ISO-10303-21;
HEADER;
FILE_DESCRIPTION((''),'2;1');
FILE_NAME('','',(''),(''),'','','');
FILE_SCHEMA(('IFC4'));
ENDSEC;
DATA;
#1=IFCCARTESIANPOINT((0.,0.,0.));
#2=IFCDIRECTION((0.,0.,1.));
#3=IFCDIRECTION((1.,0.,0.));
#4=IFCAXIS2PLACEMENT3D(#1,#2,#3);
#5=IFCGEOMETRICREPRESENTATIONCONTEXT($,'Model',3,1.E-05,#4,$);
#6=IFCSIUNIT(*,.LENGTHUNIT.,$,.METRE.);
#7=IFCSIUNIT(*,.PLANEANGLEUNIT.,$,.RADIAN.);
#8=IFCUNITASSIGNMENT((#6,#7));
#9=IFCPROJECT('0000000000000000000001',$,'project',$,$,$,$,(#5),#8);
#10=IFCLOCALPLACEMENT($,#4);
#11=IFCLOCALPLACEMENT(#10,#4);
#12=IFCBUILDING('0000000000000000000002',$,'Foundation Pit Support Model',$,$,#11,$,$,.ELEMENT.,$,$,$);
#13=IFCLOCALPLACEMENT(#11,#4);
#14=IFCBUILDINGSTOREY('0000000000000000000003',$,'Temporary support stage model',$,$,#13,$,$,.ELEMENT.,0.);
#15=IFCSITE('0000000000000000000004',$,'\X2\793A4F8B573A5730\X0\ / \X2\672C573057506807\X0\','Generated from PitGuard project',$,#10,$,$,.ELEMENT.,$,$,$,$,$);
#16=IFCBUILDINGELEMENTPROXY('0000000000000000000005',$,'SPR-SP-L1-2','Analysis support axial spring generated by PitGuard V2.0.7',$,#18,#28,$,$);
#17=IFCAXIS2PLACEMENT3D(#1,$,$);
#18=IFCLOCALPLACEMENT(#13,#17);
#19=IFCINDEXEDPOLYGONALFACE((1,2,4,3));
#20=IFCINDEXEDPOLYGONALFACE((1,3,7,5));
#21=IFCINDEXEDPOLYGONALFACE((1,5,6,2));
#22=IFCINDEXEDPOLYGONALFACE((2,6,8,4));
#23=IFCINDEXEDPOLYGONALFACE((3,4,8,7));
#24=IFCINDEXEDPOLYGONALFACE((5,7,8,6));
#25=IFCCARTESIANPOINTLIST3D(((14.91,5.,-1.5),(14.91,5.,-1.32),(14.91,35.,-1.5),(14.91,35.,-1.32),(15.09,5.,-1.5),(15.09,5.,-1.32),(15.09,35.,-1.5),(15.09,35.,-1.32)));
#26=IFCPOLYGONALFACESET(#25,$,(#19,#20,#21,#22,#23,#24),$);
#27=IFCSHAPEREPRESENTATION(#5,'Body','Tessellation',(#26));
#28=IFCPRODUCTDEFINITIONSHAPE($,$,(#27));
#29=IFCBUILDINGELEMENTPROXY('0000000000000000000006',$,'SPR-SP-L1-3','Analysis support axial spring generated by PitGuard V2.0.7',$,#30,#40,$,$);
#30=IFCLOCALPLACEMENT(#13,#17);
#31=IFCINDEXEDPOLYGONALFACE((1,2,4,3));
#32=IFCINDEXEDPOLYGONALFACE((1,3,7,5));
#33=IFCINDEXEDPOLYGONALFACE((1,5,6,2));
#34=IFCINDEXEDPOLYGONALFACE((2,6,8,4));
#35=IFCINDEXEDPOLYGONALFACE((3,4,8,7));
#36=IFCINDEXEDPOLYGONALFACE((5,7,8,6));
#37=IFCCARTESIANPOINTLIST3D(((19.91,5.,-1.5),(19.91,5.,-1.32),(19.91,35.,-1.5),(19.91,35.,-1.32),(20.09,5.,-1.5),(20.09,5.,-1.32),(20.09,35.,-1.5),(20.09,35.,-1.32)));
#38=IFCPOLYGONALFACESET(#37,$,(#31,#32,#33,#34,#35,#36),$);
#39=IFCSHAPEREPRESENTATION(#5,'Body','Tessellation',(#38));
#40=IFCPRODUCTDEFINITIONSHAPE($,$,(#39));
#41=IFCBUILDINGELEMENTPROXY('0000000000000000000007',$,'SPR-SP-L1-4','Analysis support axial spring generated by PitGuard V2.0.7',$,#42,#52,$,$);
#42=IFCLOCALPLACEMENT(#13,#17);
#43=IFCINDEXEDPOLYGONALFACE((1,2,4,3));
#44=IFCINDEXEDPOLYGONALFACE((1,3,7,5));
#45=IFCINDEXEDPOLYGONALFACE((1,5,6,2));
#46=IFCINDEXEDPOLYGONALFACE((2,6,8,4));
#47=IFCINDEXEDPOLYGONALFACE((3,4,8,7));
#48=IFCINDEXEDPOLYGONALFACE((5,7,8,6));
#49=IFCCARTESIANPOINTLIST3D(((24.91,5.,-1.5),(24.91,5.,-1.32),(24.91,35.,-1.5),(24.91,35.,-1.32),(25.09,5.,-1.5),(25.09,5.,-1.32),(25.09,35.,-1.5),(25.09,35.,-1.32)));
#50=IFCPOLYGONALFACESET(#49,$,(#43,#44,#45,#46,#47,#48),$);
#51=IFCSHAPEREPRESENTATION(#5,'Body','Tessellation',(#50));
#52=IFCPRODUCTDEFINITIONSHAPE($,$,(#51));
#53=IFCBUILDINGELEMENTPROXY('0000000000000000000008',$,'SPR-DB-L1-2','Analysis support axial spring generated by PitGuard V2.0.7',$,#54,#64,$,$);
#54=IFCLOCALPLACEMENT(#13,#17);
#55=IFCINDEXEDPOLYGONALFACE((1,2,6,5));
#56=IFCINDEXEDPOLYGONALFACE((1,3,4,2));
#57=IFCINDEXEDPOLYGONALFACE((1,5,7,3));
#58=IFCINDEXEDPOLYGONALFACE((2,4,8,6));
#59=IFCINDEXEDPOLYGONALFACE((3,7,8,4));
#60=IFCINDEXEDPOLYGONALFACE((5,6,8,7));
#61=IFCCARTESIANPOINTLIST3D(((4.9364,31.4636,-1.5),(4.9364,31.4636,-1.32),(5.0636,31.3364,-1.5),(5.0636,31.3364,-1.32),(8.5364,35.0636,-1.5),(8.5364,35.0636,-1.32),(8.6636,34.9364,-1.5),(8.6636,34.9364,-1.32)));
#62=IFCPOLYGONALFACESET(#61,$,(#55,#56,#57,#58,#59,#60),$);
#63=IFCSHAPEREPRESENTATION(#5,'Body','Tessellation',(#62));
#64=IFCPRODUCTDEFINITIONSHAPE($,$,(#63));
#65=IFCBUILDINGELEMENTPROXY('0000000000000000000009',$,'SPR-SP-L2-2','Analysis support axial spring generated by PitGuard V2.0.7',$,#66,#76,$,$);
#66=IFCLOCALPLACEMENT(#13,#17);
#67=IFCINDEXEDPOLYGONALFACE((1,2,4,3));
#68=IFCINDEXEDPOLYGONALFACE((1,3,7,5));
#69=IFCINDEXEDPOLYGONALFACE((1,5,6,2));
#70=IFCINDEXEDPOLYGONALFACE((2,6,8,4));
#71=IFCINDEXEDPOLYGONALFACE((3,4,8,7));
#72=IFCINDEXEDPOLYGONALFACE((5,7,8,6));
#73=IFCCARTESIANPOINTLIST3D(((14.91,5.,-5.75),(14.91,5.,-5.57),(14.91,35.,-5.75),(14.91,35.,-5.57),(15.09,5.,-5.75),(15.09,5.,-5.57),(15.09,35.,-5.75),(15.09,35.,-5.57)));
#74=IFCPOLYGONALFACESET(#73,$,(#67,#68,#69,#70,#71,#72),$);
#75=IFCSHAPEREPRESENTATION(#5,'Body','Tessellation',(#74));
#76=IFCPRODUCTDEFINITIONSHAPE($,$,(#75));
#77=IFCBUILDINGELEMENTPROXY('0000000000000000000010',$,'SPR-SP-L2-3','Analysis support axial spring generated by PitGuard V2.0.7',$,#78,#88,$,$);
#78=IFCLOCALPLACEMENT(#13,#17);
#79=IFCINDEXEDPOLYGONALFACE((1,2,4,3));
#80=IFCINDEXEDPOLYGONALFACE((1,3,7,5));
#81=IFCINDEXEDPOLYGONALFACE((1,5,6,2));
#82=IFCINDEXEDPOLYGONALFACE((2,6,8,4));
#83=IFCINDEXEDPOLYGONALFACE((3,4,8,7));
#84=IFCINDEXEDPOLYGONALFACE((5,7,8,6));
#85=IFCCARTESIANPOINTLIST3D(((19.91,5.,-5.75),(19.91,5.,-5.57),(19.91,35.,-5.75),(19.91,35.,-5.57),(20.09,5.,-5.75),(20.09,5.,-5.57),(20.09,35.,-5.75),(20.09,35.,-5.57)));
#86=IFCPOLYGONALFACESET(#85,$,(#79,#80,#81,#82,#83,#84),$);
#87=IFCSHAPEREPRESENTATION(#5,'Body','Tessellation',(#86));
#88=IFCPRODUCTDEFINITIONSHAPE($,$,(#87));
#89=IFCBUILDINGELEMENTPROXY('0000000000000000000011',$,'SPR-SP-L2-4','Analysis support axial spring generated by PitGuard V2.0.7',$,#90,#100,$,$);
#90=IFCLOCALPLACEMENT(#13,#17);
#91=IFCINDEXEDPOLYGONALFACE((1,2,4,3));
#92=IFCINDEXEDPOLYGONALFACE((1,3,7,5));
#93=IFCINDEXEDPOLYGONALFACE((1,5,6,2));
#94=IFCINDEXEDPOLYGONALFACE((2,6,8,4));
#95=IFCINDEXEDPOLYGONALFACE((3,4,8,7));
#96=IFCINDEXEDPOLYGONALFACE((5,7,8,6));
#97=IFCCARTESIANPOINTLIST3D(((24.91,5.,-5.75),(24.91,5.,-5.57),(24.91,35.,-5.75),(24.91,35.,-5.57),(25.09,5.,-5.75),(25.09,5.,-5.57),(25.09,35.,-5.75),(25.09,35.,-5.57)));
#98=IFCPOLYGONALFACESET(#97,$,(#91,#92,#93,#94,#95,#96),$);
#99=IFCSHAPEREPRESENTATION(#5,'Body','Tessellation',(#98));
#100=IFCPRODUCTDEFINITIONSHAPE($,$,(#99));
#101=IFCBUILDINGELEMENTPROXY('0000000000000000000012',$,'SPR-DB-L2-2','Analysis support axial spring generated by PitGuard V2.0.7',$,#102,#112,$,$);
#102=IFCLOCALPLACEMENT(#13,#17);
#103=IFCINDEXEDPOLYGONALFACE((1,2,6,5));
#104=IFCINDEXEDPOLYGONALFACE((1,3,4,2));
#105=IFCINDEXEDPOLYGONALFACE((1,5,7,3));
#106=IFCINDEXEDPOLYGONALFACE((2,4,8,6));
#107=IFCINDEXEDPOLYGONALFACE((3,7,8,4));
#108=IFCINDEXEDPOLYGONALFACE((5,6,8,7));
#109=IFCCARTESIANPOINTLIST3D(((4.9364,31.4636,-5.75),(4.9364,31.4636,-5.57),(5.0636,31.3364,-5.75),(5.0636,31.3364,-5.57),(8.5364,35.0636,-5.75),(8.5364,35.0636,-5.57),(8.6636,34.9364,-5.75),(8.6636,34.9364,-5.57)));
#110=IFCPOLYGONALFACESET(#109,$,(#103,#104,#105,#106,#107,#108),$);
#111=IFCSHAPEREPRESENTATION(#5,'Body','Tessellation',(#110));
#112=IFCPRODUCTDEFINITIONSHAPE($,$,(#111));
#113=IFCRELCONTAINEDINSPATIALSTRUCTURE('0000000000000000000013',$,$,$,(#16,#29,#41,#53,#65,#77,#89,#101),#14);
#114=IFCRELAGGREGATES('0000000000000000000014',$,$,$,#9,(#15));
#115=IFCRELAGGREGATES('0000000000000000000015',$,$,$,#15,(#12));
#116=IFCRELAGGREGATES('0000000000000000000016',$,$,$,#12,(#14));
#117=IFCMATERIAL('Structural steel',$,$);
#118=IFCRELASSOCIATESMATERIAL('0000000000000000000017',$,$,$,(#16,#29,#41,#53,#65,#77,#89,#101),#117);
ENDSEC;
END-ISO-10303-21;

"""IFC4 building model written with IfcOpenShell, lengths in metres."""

from ifc_helpers import new_model, si_unit, frame, origin_with_axes, origin_2d, place, context, project, spatial, rectangle, extrude, material, element, save


model = new_model("IFC4")

# Units and contexts
model_context = context("Model", 3, precision=1e-05, world=origin_with_axes())
ifc_project = project(units=[si_unit("LENGTHUNIT", "METRE"), si_unit("PLANEANGLEUNIT", "RADIAN")], contexts=[model_context])

# Site, building, storey
site_placement = place(None, origin_with_axes())
site = spatial("IfcSite", under=ifc_project, at=site_placement, Name="示例场地 / 本地坐标", Description="Generated from PitGuard project", CompositionType="ELEMENT")
building_placement = place(site_placement, origin_with_axes())
building = spatial("IfcBuilding", under=site, at=building_placement, Name="Foundation Pit Support Model", CompositionType="ELEMENT")
storey_placement = place(building_placement, origin_with_axes())
storey = spatial("IfcBuildingStorey", under=building, at=storey_placement, Name="Temporary support stage model", CompositionType="ELEMENT", Elevation=0.0)

# Building element proxies
ifc_material_1 = material(Name="Structural steel")
for number, where, z_axis, x_axis, name in (
    (1, (15.0, 20.0, -1.5), (0.0, 0.0, 1.0), (0.0, 1.0, 0.0), "SPR-SP-L1-2"),
    (2, (20.0, 20.0, -1.5), (0.0, 0.0, 1.0), (0.0, 1.0, 0.0), "SPR-SP-L1-3"),
    (3, (25.0, 20.0, -1.5), (0.0, 0.0, 1.0), (0.0, 1.0, 0.0), "SPR-SP-L1-4"),
):
    element("IfcBuildingElementProxy", number, at=place(storey_placement, frame(where, z_axis=z_axis, x_axis=x_axis)), inside=storey, material=ifc_material_1, Name=name, Description="Analysis support axial spring generated by PitGuard V2.0.7", context=model_context, shape_type="SweptSolid", body=[
        extrude(rectangle(XDim=30.0, YDim=0.18, at=origin_2d()), origin_with_axes(), (0.0, 0.0, 1.0), 0.18),
    ])
proxy_1_placement = place(storey_placement, frame((6.8, 33.2, -1.5), z_axis=(0.0, 0.0, 1.0), x_axis=(-0.707107, -0.707107, 0.0)))
element("IfcBuildingElementProxy", 4, at=proxy_1_placement, inside=storey, material=ifc_material_1, Name="SPR-DB-L1-2", Description="Analysis support axial spring generated by PitGuard V2.0.7", context=model_context, shape_type="SweptSolid", body=[
    extrude(rectangle(XDim=5.0912, YDim=0.18, at=origin_2d()), origin_with_axes(), (0.0, 0.0, 1.0), 0.18),
])
for number, where, z_axis, x_axis, name in (
    (5, (15.0, 20.0, -5.75), (0.0, 0.0, 1.0), (0.0, 1.0, 0.0), "SPR-SP-L2-2"),
    (6, (20.0, 20.0, -5.75), (0.0, 0.0, 1.0), (0.0, 1.0, 0.0), "SPR-SP-L2-3"),
    (7, (25.0, 20.0, -5.75), (0.0, 0.0, 1.0), (0.0, 1.0, 0.0), "SPR-SP-L2-4"),
):
    element("IfcBuildingElementProxy", number, at=place(storey_placement, frame(where, z_axis=z_axis, x_axis=x_axis)), inside=storey, material=ifc_material_1, Name=name, Description="Analysis support axial spring generated by PitGuard V2.0.7", context=model_context, shape_type="SweptSolid", body=[
        extrude(rectangle(XDim=30.0, YDim=0.18, at=origin_2d()), origin_with_axes(), (0.0, 0.0, 1.0), 0.18),
    ])
proxy_2_placement = place(storey_placement, frame((6.8, 33.2, -5.75), z_axis=(0.0, 0.0, 1.0), x_axis=(-0.707107, -0.707107, 0.0)))
element("IfcBuildingElementProxy", 8, at=proxy_2_placement, inside=storey, material=ifc_material_1, Name="SPR-DB-L2-2", Description="Analysis support axial spring generated by PitGuard V2.0.7", context=model_context, shape_type="SweptSolid", body=[
    extrude(rectangle(XDim=5.0912, YDim=0.18, at=origin_2d()), origin_with_axes(), (0.0, 0.0, 1.0), 0.18),
])

save(model, "model.ifc")
